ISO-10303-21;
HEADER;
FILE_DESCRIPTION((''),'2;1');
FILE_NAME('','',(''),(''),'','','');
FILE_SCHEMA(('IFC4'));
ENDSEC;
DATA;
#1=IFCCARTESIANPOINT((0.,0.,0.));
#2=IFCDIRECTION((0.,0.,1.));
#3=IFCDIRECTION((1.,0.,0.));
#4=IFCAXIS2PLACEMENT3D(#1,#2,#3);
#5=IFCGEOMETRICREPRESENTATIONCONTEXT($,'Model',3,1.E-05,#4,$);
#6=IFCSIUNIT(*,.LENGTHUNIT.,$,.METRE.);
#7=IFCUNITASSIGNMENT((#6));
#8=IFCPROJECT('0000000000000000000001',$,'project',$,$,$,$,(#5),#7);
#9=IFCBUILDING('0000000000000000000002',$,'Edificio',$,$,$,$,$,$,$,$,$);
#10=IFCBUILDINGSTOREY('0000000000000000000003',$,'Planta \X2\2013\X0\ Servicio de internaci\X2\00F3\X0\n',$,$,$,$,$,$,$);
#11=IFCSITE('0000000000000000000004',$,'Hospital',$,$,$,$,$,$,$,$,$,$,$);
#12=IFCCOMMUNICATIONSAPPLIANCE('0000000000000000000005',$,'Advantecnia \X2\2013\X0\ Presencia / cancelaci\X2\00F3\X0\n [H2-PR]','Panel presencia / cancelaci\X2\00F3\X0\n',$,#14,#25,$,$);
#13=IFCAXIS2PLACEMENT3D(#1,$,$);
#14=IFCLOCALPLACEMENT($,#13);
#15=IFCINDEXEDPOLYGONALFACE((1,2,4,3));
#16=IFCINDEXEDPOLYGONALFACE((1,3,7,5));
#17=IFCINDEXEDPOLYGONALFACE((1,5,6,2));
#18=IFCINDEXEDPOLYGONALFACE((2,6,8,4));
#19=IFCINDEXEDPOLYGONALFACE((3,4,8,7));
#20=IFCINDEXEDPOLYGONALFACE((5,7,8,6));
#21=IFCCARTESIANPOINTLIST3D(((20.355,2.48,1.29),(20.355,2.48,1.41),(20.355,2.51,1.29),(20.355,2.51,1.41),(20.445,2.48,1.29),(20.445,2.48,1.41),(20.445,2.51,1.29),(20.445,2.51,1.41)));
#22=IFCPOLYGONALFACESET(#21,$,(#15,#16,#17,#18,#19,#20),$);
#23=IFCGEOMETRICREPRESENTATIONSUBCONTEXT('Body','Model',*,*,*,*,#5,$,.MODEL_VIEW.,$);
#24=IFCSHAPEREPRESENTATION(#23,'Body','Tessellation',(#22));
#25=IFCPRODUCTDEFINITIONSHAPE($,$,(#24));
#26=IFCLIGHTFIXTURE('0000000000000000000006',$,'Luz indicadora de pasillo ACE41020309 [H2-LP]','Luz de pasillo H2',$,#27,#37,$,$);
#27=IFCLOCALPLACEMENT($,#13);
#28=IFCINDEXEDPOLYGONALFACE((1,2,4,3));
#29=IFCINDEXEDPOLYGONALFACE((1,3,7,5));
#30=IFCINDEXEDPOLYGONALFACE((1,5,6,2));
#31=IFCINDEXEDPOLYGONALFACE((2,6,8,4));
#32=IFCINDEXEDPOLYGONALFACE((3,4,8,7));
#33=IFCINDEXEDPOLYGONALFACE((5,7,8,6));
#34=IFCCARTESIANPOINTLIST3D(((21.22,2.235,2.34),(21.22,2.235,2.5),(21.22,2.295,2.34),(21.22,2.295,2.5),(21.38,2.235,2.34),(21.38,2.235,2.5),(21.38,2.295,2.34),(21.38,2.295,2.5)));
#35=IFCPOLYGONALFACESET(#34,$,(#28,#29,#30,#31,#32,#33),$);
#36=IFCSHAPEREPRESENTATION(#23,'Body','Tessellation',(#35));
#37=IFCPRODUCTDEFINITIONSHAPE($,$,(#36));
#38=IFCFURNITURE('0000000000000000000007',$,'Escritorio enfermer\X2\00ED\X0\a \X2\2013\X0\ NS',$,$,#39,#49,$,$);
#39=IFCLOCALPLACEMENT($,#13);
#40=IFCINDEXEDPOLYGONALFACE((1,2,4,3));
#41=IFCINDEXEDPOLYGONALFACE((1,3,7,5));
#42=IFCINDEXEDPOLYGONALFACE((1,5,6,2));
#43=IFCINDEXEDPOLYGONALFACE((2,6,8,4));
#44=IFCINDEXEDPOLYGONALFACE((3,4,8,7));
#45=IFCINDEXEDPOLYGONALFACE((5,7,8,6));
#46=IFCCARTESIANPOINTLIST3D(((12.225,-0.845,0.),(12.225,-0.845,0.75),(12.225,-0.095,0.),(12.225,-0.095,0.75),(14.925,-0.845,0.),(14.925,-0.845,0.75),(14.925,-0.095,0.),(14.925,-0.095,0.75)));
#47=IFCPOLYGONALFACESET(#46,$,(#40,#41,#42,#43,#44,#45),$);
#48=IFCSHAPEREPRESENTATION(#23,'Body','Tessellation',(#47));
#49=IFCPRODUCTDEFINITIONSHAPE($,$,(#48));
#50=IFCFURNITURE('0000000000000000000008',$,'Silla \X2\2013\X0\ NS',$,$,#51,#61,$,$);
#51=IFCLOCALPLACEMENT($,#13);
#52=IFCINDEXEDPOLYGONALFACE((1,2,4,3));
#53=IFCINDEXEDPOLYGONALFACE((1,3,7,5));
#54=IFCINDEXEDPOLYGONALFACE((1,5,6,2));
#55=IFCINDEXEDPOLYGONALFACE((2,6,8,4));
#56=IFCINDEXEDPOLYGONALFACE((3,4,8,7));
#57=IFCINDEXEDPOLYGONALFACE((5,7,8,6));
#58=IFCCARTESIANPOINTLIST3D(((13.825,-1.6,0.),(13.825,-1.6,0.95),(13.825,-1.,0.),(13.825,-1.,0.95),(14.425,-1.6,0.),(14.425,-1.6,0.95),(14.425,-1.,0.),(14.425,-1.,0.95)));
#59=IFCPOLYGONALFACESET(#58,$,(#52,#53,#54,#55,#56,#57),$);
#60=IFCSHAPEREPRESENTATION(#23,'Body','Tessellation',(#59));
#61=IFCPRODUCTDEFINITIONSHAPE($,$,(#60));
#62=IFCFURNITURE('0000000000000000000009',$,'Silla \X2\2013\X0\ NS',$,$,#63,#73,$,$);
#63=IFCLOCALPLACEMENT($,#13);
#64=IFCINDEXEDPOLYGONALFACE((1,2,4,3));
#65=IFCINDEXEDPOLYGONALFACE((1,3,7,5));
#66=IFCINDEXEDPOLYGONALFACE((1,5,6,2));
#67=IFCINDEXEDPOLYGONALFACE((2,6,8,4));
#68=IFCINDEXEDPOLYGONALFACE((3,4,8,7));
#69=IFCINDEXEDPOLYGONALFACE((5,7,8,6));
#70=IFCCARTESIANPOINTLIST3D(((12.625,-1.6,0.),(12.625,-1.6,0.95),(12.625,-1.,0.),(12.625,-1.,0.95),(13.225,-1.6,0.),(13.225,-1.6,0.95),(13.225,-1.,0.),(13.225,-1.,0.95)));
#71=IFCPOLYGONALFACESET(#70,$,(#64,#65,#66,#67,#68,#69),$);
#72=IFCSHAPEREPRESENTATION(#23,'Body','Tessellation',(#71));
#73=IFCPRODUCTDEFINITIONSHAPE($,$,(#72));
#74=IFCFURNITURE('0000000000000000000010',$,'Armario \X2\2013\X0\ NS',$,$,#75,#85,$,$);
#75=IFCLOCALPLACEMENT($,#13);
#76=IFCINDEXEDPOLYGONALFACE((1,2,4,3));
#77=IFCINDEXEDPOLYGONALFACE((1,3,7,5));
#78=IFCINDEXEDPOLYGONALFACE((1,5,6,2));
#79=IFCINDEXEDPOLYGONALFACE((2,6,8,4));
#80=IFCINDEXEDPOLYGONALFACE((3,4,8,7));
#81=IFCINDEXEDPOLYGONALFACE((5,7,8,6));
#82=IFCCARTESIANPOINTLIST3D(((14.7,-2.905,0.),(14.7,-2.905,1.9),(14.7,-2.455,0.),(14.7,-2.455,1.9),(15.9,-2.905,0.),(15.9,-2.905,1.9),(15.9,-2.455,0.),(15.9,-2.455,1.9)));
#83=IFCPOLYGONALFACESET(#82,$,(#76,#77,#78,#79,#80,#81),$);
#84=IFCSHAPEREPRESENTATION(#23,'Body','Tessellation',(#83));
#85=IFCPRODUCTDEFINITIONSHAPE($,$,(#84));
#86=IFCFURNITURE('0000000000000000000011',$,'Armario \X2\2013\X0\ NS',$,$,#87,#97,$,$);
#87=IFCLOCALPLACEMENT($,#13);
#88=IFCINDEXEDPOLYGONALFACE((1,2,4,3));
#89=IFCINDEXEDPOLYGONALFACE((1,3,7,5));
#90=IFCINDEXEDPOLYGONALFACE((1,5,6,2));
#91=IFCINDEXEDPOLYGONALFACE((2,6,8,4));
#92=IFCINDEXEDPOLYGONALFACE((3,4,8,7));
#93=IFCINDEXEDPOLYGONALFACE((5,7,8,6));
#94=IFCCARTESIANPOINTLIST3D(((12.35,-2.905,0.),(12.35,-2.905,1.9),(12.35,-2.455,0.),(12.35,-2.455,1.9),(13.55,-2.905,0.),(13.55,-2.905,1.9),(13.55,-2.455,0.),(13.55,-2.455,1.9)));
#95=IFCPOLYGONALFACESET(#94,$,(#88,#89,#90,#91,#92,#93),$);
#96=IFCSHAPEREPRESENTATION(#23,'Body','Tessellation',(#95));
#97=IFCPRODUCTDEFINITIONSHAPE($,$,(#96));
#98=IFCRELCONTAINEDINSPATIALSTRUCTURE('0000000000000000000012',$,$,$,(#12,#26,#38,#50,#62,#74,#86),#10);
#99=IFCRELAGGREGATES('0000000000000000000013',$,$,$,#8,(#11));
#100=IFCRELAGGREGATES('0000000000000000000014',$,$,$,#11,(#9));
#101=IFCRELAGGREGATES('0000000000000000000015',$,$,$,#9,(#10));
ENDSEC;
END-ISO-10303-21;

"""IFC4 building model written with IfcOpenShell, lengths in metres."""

from ifc_helpers import new_model, si_unit, frame, origin_with_axes, context, subcontext, project, spatial, line, indexed_curve, outline, extrude, element, save


model = new_model("IFC4")

# Units and contexts
model_context = context("Model", 3, precision=1e-05, world=origin_with_axes())
body_context = subcontext(model_context, "Body", "Model", "MODEL_VIEW")
ifc_project = project(units=[si_unit("LENGTHUNIT", "METRE")], contexts=[model_context])

# Site, building, storey
site = spatial("IfcSite", under=ifc_project, Name="Hospital")
building = spatial("IfcBuilding", under=site, Name="Edificio")
storey = spatial("IfcBuildingStorey", under=building, Name="Planta – Servicio de internación")

# Communications appliance
element("IfcCommunicationsAppliance", 1, inside=storey, Name="Advantecnia – Presencia / cancelación [H2-PR]", Description="Panel presencia / cancelación", context=body_context, shape_type="SweptSolid", body=[
    extrude(outline(indexed_curve([(0.0, 0.0), (0.09, 0.0), (0.09, 0.03), (0.0, 0.03)], segments=[line(1, 2, 3, 4, 1)])), frame((20.355, 2.48, 1.29), z_axis=(0.0, 0.0, 1.0), x_axis=(1.0, 0.0, 0.0)), (0.0, 0.0, 1.0), 0.12),
])

# Light fixture
element("IfcLightFixture", 2, inside=storey, Name="Luz indicadora de pasillo ACE41020309 [H2-LP]", Description="Luz de pasillo H2", context=body_context, shape_type="SweptSolid", body=[
    extrude(outline(indexed_curve([(0.0, 0.0), (0.16, 0.0), (0.16, 0.06), (0.0, 0.06)], segments=[line(1, 2, 3, 4, 1)])), frame((21.22, 2.235, 2.34), z_axis=(0.0, 0.0, 1.0), x_axis=(1.0, 0.0, 0.0)), (0.0, 0.0, 1.0), 0.16),
])

# Furniture
element("IfcFurniture", 3, inside=storey, Name="Escritorio enfermería – NS", context=body_context, shape_type="SweptSolid", body=[
    extrude(outline(indexed_curve([(0.0, 0.0), (2.7, 0.0), (2.7, 0.75), (0.0, 0.75)], segments=[line(1, 2, 3, 4, 1)])), frame((12.225, -0.845, 0.0), z_axis=(0.0, 0.0, 1.0), x_axis=(1.0, 0.0, 0.0)), (0.0, 0.0, 1.0), 0.75),
])
element("IfcFurniture", 4, inside=storey, Name="Silla – NS", context=body_context, shape_type="SweptSolid", body=[
    extrude(outline(indexed_curve([(0.0, 0.0), (0.6, 0.0), (0.6, 0.6), (0.0, 0.6)], segments=[line(1, 2, 3, 4, 1)])), frame((13.825, -1.6, 0.0), z_axis=(0.0, 0.0, 1.0), x_axis=(1.0, 0.0, 0.0)), (0.0, 0.0, 1.0), 0.95),
])
element("IfcFurniture", 5, inside=storey, Name="Silla – NS", context=body_context, shape_type="SweptSolid", body=[
    extrude(outline(indexed_curve([(0.0, 0.0), (0.6, 0.0), (0.6, 0.6), (0.0, 0.6)], segments=[line(1, 2, 3, 4, 1)])), frame((12.625, -1.6, 0.0), z_axis=(0.0, 0.0, 1.0), x_axis=(1.0, 0.0, 0.0)), (0.0, 0.0, 1.0), 0.95),
])
element("IfcFurniture", 6, inside=storey, Name="Armario – NS", context=body_context, shape_type="SweptSolid", body=[
    extrude(outline(indexed_curve([(0.0, 0.0), (1.2, 0.0), (1.2, 0.45), (0.0, 0.45)], segments=[line(1, 2, 3, 4, 1)])), frame((14.7, -2.905, 0.0), z_axis=(0.0, 0.0, 1.0), x_axis=(1.0, 0.0, 0.0)), (0.0, 0.0, 1.0), 1.9),
])
element("IfcFurniture", 7, inside=storey, Name="Armario – NS", context=body_context, shape_type="SweptSolid", body=[
    extrude(outline(indexed_curve([(0.0, 0.0), (1.2, 0.0), (1.2, 0.45), (0.0, 0.45)], segments=[line(1, 2, 3, 4, 1)])), frame((12.35, -2.905, 0.0), z_axis=(0.0, 0.0, 1.0), x_axis=(1.0, 0.0, 0.0)), (0.0, 0.0, 1.0), 1.9),
])

save(model, "model.ifc")
